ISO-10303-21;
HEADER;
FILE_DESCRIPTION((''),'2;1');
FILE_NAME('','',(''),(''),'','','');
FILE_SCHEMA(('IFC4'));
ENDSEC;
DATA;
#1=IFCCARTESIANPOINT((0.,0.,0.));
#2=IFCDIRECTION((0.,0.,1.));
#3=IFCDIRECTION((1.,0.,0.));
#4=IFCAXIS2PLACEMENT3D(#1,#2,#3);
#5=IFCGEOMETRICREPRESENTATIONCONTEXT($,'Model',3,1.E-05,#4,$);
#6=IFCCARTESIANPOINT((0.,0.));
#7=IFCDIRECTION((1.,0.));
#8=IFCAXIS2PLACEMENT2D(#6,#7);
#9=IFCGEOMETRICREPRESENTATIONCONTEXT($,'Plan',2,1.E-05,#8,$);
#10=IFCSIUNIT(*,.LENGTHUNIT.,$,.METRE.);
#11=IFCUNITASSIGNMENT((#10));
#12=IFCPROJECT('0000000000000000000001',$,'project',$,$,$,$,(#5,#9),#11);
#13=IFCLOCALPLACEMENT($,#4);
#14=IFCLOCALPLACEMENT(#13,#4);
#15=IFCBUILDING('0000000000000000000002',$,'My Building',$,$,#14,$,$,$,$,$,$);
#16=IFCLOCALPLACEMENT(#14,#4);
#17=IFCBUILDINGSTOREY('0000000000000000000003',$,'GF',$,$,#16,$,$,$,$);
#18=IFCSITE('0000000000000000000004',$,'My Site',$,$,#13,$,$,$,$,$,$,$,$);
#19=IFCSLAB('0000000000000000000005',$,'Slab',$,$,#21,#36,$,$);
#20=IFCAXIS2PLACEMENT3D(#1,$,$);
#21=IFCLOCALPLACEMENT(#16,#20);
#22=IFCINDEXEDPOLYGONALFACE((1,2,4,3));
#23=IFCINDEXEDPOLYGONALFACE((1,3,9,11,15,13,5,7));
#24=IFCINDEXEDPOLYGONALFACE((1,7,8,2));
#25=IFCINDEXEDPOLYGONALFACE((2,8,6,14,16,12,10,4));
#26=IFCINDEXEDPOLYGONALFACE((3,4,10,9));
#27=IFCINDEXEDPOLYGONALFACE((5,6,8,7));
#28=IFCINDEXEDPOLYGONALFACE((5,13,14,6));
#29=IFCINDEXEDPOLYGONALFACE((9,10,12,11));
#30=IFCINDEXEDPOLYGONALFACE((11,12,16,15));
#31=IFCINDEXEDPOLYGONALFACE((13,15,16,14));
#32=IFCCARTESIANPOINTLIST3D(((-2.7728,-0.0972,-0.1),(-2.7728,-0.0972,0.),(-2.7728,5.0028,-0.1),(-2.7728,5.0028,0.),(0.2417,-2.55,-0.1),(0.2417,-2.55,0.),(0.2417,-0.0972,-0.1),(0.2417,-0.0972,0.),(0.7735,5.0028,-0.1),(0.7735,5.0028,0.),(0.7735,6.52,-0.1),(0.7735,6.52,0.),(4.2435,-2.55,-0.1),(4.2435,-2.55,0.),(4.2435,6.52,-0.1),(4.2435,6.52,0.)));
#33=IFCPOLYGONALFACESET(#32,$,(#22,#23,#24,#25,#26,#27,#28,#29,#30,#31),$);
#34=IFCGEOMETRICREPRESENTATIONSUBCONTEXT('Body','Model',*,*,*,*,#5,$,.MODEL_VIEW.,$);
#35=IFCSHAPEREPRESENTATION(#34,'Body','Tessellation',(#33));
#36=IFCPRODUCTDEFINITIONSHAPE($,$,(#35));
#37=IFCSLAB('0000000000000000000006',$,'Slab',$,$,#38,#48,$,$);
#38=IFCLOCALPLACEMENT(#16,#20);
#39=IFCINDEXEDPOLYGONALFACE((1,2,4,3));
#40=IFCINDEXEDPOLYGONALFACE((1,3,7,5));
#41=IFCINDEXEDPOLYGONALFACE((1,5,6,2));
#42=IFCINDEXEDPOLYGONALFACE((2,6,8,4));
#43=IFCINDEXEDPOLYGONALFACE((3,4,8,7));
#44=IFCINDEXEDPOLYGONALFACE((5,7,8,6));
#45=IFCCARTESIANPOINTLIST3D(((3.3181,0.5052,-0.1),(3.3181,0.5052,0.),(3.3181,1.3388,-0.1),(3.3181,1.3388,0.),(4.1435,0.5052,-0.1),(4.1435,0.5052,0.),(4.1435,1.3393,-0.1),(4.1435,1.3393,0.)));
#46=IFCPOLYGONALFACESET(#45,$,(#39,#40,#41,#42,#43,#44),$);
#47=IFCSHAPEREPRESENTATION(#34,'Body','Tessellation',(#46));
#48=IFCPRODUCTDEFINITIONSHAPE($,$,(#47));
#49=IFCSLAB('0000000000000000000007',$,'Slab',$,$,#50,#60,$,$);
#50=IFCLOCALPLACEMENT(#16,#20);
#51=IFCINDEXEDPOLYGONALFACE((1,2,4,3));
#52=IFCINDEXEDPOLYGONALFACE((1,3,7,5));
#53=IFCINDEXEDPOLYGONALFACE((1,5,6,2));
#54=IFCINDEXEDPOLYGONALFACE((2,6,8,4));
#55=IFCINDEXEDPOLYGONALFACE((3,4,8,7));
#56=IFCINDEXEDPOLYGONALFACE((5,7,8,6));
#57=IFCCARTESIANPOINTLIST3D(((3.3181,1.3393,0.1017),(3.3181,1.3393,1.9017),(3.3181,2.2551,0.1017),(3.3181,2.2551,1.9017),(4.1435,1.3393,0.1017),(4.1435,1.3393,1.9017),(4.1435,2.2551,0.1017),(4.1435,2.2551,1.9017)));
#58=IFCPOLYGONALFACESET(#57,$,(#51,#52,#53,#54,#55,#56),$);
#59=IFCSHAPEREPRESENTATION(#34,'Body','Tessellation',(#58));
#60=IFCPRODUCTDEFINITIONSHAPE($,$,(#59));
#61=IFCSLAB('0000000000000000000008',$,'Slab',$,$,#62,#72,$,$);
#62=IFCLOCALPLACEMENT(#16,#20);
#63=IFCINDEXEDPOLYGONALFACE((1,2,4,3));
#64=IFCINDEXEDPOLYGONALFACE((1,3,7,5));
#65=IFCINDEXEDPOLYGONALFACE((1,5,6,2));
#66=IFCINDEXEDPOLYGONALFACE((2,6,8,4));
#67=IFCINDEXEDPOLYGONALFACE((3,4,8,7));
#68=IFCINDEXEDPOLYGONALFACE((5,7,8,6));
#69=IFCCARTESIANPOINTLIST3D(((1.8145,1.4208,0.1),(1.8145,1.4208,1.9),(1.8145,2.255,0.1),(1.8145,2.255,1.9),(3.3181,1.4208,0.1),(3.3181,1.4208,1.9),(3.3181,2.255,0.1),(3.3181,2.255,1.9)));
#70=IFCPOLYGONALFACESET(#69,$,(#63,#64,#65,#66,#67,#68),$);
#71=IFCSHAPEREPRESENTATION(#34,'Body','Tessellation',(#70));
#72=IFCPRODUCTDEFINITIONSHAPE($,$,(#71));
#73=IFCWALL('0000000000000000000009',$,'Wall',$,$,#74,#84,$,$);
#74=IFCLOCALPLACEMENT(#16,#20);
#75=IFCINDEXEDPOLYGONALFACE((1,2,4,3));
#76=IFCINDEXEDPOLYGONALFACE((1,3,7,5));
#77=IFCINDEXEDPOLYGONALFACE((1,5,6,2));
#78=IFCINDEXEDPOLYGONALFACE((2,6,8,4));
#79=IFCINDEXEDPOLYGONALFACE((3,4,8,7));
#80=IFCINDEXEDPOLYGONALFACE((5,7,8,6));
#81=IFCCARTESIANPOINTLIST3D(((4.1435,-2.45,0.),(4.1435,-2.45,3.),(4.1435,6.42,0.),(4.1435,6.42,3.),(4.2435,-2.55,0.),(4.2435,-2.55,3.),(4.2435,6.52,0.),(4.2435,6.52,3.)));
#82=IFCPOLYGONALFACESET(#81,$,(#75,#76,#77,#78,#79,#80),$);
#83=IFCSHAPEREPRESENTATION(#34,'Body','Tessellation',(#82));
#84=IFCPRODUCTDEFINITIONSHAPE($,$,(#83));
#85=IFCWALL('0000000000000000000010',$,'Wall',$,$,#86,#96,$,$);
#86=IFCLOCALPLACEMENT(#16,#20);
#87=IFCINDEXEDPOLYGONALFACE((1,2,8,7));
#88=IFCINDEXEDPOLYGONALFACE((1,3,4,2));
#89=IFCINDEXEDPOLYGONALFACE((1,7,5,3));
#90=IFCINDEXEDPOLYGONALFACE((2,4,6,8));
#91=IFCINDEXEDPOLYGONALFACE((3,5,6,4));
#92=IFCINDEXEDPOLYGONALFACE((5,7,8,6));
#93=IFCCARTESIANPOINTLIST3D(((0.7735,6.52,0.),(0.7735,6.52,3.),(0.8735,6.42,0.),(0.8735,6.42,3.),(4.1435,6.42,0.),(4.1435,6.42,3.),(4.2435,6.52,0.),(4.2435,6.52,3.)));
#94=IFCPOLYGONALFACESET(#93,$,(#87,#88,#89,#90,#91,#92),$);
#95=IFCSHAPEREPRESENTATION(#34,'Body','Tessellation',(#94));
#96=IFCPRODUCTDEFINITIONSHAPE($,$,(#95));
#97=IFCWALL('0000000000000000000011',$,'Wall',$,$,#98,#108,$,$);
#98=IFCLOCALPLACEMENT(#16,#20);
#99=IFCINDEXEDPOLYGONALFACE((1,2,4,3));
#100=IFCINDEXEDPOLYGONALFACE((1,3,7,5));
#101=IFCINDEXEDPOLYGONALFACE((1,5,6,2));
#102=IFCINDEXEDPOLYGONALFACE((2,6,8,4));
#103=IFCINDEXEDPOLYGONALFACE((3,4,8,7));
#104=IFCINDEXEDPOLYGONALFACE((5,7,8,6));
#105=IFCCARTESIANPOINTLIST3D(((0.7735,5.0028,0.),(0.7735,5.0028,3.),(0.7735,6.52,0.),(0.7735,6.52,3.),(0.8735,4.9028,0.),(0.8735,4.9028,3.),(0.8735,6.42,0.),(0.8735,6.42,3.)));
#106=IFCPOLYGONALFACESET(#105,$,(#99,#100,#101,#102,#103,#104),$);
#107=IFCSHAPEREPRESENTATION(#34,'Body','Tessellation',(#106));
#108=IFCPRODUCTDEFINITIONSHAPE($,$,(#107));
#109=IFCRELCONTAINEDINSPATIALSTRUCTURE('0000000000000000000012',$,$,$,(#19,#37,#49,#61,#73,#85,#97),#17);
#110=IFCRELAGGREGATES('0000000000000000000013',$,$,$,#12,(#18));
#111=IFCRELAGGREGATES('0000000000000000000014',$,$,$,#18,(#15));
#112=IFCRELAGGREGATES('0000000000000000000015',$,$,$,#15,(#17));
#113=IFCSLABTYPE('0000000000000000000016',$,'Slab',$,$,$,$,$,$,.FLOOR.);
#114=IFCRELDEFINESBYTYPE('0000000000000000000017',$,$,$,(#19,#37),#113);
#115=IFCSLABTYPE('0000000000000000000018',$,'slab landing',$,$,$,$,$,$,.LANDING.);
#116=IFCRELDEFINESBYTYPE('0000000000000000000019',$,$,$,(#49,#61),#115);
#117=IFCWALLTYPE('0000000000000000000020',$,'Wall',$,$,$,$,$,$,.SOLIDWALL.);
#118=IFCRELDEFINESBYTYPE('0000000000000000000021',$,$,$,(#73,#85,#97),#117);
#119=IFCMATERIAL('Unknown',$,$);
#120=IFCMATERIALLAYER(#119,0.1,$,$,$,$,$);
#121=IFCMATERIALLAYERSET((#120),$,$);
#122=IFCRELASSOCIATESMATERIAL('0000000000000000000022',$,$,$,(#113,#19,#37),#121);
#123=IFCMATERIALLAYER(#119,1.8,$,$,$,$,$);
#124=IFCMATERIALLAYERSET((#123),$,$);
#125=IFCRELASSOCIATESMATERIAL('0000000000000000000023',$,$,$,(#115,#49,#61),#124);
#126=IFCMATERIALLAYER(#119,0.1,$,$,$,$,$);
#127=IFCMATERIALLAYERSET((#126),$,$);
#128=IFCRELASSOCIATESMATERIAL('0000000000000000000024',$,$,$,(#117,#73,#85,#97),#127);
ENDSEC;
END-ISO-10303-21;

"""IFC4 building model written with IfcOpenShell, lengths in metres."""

from ifc_helpers import new_model, si_unit, frame, origin_with_axes, origin_2d_with_axis, place, context, subcontext, project, spatial, line, indexed_curve, outline, extrude, material, layer, layer_set, layer_usage, type_object, element, save


model = new_model("IFC4")

# Units and contexts
model_context = context("Model", 3, precision=1e-05, world=origin_with_axes())
plan_context = context("Plan", 2, precision=1e-05, world=origin_2d_with_axis())
body_context_1 = subcontext(model_context, "Body", "Model", "MODEL_VIEW")
ifc_project = project(units=[si_unit("LENGTHUNIT", "METRE")], contexts=[model_context, plan_context])

# Site, building, storey
site_placement = place(None, origin_with_axes())
site = spatial("IfcSite", under=ifc_project, at=site_placement, Name="My Site")
building_placement = place(site_placement, origin_with_axes())
building = spatial("IfcBuilding", under=site, at=building_placement, Name="My Building")
storey_placement = place(building_placement, origin_with_axes())
storey = spatial("IfcBuildingStorey", under=building, at=storey_placement, Name="GF")

# Slabs
ifc_material_1 = material(Name="Unknown")
ifc_layer_1 = layer(ifc_material_1, 0.1)
ifc_layer_set_1 = layer_set([ifc_layer_1])
ifc_layer_usage_1 = layer_usage(ifc_layer_set_1, "AXIS3", "POSITIVE", -0.1)
slab_type_1 = type_object("IfcSlabType", Name="Slab", PredefinedType="FLOOR", material=ifc_layer_set_1)
slab_1_placement = place(storey_placement, frame((4.2435, 6.52, 0.0), z_axis=(0.0, 0.0, 1.0), x_axis=(1.0, 0.0, 0.0)))
element("IfcSlab", 1, at=slab_1_placement, inside=storey, type_object=slab_type_1, material=ifc_layer_usage_1, Name="Slab", context=body_context_1, shape_type="SweptSolid", body=[
    extrude(outline(indexed_curve([(0.0, 0.0), (-3.47, 0.0), (-3.47, -1.5172), (-7.0163, -1.5172), (-7.0163, -6.6172), (-4.0018, -6.6172), (-4.0018, -9.07), (0.0, -9.07), (0.0, 0.0)])), frame((0.0, 0.0, -0.1), z_axis=(0.0, 0.0, 1.0), x_axis=(1.0, 0.0, 0.0)), (0.0, 0.0, 1.0), 0.1),
])
ifc_layer_usage_2 = layer_usage(ifc_layer_set_1, "AXIS3", "POSITIVE", -0.1)
slab_2_placement = place(storey_placement, frame((3.3181, 1.3388, 0.0), z_axis=(0.0, 0.0, 1.0), x_axis=(1.0, 0.0, 0.0)))
element("IfcSlab", 2, at=slab_2_placement, inside=storey, type_object=slab_type_1, material=ifc_layer_usage_2, Name="Slab", context=body_context_1, shape_type="SweptSolid", body=[
    extrude(outline(indexed_curve([(0.0, 0.0), (0.0, -0.8336), (0.8254, -0.8336), (0.8254, 0.0005), (0.0, 0.0)])), frame((0.0, 0.0, -0.1), z_axis=(0.0, 0.0, 1.0), x_axis=(1.0, 0.0, 0.0)), (0.0, 0.0, 1.0), 0.1),
])
ifc_layer_2 = layer(ifc_material_1, 1.8)
ifc_layer_set_2 = layer_set([ifc_layer_2])
slab_type_2 = type_object("IfcSlabType", Name="slab landing", PredefinedType="LANDING", material=ifc_layer_set_2)
ifc_layer_usage_3 = layer_usage(ifc_layer_set_2, "AXIS3", "POSITIVE", -1.8)
slab_3_placement = place(storey_placement, frame((4.1435, 1.3393, 1.9017), z_axis=(0.0, 0.0, 1.0), x_axis=(1.0, 0.0, 0.0)))
element("IfcSlab", 3, at=slab_3_placement, inside=storey, type_object=slab_type_2, material=ifc_layer_usage_3, Name="Slab", context=body_context_1, shape_type="SweptSolid", body=[
    extrude(outline(indexed_curve([(0.0, 0.0), (0.0, 0.9157), (-0.8254, 0.9157), (-0.8254, 0.0), (0.0, 0.0)])), frame((0.0, 0.0, -1.8), z_axis=(0.0, 0.0, 1.0), x_axis=(1.0, 0.0, 0.0)), (0.0, 0.0, 1.0), 1.8),
])
ifc_layer_usage_4 = layer_usage(ifc_layer_set_2, "AXIS3", "POSITIVE", -1.8)
slab_4_placement = place(storey_placement, frame((3.3181, 1.4208, 1.9), z_axis=(0.0, 0.0, 1.0), x_axis=(1.0, 0.0, 0.0)))
element("IfcSlab", 4, at=slab_4_placement, inside=storey, type_object=slab_type_2, material=ifc_layer_usage_4, Name="Slab", context=body_context_1, shape_type="SweptSolid", body=[
    extrude(outline(indexed_curve([(0.0, 0.0), (-1.5036, 0.0), (-1.5036, 0.8342), (0.0, 0.8342), (0.0, 0.0)])), frame((0.0, 0.0, -1.8), z_axis=(0.0, 0.0, 1.0), x_axis=(1.0, 0.0, 0.0)), (0.0, 0.0, 1.0), 1.8),
])

# Shared definitions
ifc_layer_3 = layer(ifc_material_1, 0.1)
ifc_layer_set_3 = layer_set([ifc_layer_3])
wall_type = type_object("IfcWallType", Name="Wall", PredefinedType="SOLIDWALL", material=ifc_layer_set_3)

# Walls
ifc_layer_usage_5 = layer_usage(ifc_layer_set_3, "AXIS2", "POSITIVE", 0.0)
wall_1_placement = place(storey_placement, frame((4.2435, -2.45, 0.0), z_axis=(0.0, 0.0, 1.0), x_axis=(0.0, 1.0, 0.0)))
element("IfcWall", 5, at=wall_1_placement, inside=storey, type_object=wall_type, material=ifc_layer_usage_5, Name="Wall", context=body_context_1, shape_type="SweptSolid", body=[
    extrude(outline(indexed_curve([(-0.1, 0.0), (0.0, 0.1), (8.87, 0.1), (8.97, 0.0)], segments=[line(1, 2, 3, 4, 1)])), origin_with_axes(), (0.0, 0.0, 1.0), 3.0),
])
ifc_layer_usage_6 = layer_usage(ifc_layer_set_3, "AXIS2", "POSITIVE", 0.0)
wall_2_placement = place(storey_placement, frame((4.2435, 6.52, 0.0), z_axis=(0.0, 0.0, 1.0), x_axis=(-1.0, 0.0, 0.0)))
element("IfcWall", 6, at=wall_2_placement, inside=storey, type_object=wall_type, material=ifc_layer_usage_6, Name="Wall", context=body_context_1, shape_type="SweptSolid", body=[
    extrude(outline(indexed_curve([(0.0, 0.0), (0.1, 0.1), (3.37, 0.1), (3.47, 0.0)], segments=[line(1, 2, 3, 4, 1)])), origin_with_axes(), (0.0, 0.0, 1.0), 3.0),
])
ifc_layer_usage_7 = layer_usage(ifc_layer_set_3, "AXIS2", "POSITIVE", 0.0)
wall_3_placement = place(storey_placement, frame((0.7735, 6.52, 0.0), z_axis=(0.0, 0.0, 1.0), x_axis=(0.0, -1.0, 0.0)))
element("IfcWall", 7, at=wall_3_placement, inside=storey, type_object=wall_type, material=ifc_layer_usage_7, Name="Wall", context=body_context_1, shape_type="SweptSolid", body=[
    extrude(outline(indexed_curve([(0.0, 0.0), (0.1, 0.1), (1.6172, 0.1), (1.5172, 0.0)], segments=[line(1, 2, 3, 4, 1)])), origin_with_axes(), (0.0, 0.0, 1.0), 3.0),
])

save(model, "model.ifc")
